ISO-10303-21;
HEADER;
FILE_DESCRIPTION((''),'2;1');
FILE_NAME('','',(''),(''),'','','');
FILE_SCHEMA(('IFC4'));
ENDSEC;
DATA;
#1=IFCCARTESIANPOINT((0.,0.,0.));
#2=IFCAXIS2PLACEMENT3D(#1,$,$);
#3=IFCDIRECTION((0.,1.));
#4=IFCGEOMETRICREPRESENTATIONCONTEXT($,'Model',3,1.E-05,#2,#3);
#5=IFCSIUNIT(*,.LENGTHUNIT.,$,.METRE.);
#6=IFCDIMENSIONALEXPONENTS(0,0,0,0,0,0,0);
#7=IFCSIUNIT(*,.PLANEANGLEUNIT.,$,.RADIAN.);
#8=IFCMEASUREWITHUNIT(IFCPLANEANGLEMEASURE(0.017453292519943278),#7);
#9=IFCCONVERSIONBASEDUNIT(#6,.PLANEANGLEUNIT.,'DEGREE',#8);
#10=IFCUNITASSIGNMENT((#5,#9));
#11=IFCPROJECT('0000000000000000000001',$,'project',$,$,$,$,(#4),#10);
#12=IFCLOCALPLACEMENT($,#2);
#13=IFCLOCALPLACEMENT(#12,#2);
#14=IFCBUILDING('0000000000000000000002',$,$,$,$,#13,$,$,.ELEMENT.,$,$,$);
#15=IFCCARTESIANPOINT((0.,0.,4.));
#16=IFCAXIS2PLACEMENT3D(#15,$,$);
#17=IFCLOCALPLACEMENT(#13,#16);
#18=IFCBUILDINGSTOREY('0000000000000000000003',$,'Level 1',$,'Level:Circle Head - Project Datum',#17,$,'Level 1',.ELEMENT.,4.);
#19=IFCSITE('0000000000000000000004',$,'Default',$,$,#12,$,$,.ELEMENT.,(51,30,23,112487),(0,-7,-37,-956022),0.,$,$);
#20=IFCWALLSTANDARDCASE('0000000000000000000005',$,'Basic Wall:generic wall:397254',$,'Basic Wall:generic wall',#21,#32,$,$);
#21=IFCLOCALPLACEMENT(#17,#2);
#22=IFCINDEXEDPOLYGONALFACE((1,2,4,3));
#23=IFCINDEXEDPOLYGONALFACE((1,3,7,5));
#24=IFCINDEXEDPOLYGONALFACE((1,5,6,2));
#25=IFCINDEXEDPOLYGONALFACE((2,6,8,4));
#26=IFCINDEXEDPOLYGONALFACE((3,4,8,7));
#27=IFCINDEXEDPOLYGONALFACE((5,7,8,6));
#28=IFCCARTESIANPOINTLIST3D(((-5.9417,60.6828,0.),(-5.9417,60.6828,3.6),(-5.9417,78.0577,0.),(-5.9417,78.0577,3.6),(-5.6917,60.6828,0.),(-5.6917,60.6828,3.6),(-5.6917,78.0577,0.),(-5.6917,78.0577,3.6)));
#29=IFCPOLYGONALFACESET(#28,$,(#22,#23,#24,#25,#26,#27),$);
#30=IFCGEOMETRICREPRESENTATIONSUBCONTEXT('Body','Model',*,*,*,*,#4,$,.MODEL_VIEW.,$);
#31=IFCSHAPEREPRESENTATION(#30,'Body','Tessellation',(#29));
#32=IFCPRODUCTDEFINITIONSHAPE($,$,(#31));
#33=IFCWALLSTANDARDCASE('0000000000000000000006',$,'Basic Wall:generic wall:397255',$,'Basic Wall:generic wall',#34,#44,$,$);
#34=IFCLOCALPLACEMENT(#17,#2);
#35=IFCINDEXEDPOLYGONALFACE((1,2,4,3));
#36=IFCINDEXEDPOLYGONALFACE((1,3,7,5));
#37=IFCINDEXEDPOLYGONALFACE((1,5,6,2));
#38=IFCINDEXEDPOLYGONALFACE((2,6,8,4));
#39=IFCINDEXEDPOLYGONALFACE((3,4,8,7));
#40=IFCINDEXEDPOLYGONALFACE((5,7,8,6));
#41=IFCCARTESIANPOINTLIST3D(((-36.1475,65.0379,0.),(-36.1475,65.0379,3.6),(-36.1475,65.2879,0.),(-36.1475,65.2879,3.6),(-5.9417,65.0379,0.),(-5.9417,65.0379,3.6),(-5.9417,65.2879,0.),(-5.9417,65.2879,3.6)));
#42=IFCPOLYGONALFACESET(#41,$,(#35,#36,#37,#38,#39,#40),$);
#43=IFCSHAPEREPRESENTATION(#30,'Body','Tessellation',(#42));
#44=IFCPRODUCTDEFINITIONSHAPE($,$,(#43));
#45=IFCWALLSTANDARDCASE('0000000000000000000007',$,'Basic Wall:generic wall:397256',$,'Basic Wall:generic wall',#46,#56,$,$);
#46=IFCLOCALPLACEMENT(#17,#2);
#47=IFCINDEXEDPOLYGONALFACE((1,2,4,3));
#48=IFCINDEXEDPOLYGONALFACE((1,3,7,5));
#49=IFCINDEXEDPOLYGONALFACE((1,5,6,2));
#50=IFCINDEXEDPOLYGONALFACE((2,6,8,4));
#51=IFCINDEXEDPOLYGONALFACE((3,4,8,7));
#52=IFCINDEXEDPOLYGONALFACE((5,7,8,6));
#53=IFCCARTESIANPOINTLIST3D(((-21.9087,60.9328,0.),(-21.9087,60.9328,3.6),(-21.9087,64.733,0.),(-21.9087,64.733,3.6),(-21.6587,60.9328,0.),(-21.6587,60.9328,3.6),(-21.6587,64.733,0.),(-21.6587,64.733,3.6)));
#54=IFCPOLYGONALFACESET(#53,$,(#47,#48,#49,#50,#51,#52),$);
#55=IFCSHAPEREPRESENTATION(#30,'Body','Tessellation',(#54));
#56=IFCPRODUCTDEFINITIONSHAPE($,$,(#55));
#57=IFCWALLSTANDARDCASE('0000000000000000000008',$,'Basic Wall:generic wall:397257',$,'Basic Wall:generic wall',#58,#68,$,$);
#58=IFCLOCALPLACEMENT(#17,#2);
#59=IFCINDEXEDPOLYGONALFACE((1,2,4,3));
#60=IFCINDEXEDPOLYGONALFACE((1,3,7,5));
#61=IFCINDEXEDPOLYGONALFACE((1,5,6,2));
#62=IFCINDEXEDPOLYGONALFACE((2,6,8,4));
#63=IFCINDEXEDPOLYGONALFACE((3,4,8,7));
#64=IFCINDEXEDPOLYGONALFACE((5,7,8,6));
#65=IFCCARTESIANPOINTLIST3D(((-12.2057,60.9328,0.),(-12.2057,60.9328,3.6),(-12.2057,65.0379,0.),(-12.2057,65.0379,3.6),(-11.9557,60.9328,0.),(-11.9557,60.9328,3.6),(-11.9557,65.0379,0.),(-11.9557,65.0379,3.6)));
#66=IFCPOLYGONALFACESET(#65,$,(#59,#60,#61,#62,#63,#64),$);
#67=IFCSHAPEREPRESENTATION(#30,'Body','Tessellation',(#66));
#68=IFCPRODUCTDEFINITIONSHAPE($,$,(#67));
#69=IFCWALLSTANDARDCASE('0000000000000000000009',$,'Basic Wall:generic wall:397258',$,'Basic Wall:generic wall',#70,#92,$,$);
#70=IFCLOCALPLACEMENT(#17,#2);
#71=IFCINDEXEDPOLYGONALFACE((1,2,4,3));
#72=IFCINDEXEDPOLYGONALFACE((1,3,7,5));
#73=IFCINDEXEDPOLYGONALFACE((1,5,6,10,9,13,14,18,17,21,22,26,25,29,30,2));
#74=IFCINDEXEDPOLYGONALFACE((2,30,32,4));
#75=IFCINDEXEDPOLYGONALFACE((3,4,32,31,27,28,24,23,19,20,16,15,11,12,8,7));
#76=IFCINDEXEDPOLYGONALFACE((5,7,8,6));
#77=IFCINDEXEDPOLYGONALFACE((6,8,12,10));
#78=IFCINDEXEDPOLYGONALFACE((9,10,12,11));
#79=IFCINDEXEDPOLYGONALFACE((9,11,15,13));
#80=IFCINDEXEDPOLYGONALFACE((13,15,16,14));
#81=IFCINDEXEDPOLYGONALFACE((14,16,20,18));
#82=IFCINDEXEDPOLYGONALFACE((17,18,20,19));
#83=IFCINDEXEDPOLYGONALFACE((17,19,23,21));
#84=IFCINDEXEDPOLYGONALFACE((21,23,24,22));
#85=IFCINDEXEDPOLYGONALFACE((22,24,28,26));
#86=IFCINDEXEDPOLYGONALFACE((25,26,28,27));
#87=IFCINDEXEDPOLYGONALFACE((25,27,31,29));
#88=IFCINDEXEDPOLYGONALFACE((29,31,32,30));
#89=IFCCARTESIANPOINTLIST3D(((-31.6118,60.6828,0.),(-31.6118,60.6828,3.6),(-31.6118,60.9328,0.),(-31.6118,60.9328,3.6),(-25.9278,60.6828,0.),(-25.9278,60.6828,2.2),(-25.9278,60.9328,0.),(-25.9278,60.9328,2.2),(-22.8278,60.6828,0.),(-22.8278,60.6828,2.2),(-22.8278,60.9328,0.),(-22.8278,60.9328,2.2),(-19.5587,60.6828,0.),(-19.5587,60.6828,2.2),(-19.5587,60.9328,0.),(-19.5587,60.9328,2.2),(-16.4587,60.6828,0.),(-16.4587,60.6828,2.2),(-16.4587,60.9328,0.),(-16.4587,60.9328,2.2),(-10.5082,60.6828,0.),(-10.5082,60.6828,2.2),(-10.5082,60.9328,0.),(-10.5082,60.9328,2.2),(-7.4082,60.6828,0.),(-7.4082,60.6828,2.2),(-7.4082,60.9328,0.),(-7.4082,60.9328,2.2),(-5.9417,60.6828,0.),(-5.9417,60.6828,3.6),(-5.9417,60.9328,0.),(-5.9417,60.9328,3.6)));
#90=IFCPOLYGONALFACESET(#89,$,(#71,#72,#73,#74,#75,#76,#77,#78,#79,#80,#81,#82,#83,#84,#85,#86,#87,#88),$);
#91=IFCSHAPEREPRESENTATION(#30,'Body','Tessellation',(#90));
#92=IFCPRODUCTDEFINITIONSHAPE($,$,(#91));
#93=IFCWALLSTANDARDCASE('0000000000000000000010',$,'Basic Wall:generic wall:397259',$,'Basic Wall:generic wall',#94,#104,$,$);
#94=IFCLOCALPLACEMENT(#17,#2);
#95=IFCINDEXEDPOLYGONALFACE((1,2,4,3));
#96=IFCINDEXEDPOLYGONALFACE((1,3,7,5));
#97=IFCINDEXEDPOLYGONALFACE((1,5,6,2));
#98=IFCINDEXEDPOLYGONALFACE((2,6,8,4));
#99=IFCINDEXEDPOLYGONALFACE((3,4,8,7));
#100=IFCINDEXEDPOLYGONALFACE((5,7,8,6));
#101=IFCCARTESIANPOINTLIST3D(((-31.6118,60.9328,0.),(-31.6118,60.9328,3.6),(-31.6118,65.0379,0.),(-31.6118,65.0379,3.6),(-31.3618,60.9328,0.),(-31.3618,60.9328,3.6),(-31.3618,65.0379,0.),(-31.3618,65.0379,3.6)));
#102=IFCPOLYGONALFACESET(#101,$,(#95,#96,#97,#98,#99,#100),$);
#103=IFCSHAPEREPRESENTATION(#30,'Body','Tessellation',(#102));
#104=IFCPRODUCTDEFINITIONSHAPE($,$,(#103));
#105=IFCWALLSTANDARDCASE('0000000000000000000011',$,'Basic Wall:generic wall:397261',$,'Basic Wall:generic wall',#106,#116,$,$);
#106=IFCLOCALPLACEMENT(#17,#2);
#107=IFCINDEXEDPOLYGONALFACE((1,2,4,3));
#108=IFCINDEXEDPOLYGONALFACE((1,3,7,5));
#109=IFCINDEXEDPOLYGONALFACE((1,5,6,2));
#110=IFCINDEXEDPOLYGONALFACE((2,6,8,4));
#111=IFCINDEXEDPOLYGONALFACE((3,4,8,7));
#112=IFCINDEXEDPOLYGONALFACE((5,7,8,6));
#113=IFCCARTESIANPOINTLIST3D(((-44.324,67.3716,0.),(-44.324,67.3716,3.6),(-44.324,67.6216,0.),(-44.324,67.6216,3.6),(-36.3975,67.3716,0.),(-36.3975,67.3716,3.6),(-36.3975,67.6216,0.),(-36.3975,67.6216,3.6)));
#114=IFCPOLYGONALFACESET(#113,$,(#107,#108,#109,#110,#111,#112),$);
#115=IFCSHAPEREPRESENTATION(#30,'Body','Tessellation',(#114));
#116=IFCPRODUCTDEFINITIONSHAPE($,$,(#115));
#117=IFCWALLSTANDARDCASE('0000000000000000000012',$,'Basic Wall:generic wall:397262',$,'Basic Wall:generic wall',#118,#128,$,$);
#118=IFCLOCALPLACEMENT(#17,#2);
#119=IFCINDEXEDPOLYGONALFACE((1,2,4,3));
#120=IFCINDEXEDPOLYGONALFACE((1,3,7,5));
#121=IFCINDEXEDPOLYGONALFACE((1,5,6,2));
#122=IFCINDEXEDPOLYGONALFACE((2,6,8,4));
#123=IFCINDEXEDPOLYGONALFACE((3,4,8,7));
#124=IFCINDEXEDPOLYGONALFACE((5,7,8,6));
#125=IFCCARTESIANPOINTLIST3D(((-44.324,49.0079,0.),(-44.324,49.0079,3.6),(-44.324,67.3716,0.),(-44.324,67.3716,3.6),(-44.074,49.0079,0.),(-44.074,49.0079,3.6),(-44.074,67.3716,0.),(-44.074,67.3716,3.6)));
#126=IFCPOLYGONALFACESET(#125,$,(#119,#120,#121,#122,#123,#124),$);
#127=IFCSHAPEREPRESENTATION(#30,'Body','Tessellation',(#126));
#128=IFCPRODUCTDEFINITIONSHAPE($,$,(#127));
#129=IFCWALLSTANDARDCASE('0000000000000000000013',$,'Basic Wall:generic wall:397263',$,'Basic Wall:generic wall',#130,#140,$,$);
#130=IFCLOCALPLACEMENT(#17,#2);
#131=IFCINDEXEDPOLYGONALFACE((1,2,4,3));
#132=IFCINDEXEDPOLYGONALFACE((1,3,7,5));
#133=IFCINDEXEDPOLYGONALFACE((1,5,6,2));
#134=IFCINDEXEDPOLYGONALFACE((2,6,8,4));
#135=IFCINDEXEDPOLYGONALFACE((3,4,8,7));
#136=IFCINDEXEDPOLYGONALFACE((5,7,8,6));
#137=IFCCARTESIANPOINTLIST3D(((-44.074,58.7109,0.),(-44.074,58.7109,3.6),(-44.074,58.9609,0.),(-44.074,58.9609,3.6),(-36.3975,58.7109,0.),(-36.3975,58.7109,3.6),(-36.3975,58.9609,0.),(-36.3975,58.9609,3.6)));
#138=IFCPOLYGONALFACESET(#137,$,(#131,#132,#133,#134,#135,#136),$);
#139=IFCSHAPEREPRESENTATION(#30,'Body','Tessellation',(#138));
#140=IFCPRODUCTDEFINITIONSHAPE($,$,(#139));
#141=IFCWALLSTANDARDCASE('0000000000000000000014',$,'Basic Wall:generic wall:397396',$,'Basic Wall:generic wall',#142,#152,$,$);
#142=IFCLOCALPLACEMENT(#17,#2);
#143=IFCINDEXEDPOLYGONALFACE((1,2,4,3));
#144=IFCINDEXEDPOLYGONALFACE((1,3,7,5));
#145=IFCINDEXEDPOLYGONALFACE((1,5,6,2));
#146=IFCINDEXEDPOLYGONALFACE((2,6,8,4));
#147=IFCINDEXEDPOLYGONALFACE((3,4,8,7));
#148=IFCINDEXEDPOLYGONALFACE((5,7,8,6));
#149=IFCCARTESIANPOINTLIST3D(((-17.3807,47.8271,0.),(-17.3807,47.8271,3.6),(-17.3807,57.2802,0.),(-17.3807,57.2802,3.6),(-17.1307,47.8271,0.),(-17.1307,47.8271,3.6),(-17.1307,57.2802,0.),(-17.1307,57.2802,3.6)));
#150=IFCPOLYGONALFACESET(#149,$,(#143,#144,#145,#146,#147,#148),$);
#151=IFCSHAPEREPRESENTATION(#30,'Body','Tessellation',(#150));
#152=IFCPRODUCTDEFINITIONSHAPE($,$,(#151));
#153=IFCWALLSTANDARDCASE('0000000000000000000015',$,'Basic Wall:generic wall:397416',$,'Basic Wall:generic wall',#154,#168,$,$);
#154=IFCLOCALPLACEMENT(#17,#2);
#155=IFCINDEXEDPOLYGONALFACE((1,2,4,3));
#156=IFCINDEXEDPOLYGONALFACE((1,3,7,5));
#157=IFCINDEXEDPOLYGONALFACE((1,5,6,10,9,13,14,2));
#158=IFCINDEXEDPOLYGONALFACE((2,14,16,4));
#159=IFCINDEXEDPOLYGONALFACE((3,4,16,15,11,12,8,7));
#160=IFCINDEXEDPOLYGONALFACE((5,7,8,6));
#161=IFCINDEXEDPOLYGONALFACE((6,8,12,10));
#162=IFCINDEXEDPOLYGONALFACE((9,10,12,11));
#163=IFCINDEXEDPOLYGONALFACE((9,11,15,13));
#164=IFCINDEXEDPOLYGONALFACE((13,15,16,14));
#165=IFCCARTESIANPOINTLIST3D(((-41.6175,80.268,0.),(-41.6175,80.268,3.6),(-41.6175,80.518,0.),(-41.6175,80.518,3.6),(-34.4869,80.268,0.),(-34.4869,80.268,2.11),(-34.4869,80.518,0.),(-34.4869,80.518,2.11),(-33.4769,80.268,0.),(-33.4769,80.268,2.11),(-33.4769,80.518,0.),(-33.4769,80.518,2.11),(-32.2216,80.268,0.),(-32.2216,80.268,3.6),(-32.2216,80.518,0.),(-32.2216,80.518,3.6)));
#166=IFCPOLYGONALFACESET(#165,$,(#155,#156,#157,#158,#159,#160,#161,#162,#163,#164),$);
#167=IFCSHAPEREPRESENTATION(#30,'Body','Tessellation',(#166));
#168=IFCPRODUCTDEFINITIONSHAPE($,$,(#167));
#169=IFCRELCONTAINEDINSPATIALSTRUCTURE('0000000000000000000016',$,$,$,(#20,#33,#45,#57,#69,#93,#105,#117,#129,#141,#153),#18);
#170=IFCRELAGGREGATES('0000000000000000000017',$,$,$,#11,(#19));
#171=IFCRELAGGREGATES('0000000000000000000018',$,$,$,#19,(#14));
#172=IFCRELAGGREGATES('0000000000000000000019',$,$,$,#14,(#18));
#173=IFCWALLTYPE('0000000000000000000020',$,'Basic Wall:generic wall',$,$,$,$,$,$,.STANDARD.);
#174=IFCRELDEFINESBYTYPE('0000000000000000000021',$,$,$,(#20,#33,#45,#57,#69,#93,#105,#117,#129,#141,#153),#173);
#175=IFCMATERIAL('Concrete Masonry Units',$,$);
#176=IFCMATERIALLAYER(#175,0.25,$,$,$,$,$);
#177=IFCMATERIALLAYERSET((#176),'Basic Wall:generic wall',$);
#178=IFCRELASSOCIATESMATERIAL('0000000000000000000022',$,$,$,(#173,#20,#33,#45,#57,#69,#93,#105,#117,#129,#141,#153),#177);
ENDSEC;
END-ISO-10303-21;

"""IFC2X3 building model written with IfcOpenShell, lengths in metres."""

from ifc_helpers import new_model, entity, si_unit, converted_unit, direction, frame, frame_2d, origin, place, context, subcontext, project, spatial, rectangle, extrude, material, layer, layer_set, layer_usage, type_object, element, save


model = new_model("IFC2X3")

# Units and contexts
model_context = context("Model", 3, precision=1e-05, world=origin(), true_north=direction((0.0, 1.0)))
body_context = subcontext(model_context, "Body", "Model", "MODEL_VIEW")
ifc_project = project(units=[si_unit("LENGTHUNIT", "METRE"), converted_unit("PLANEANGLEUNIT", "DEGREE", entity("IfcPlaneAngleMeasure", 0.017453292519943278), si_unit("PLANEANGLEUNIT", "RADIAN"), dimensions=[0, 0, 0, 0, 0, 0, 0])], contexts=[model_context])

# Site, building, storey
site_placement = place(None, origin())
site = spatial("IfcSite", under=ifc_project, at=site_placement, Name="Default", CompositionType="ELEMENT", RefLatitude=(51, 30, 23, 112487), RefLongitude=(0, -7, -37, -956022), RefElevation=0.0)
building_placement = place(site_placement, origin())
building = spatial("IfcBuilding", under=site, at=building_placement, CompositionType="ELEMENT")
storey_placement = place(building_placement, frame((0.0, 0.0, 4.0)))
storey = spatial("IfcBuildingStorey", under=building, at=storey_placement, Name="Level 1", ObjectType="Level:Circle Head - Project Datum", LongName="Level 1", CompositionType="ELEMENT", Elevation=4.0)

# Shared definitions
ifc_material = material(Name="Concrete Masonry Units")
ifc_layer = layer(ifc_material, 0.25)
ifc_layer_set = layer_set([ifc_layer], Name="Basic Wall:generic wall")
wall_type = type_object("IfcWallType", Name="Basic Wall:generic wall", PredefinedType="STANDARD", material=ifc_layer_set)

# Walls
ifc_layer_usage_1 = layer_usage(ifc_layer_set, "AXIS2", "NEGATIVE", 0.125)
wall_1_placement = place(storey_placement, frame((-5.8167, 78.0577, 0.0), z_axis=(0.0, 0.0, 1.0), x_axis=(0.0, -1.0, 0.0)))
element("IfcWallStandardCase", 1, at=wall_1_placement, inside=storey, type_object=wall_type, material=ifc_layer_usage_1, Name="Basic Wall:generic wall:397254", ObjectType="Basic Wall:generic wall", context=body_context, shape_type="SweptSolid", body=[
    extrude(rectangle(XDim=17.3749, YDim=0.25, at=frame_2d((8.6874, 0.0), x_axis=(-1.0, 0.0))), origin(), (0.0, 0.0, 1.0), 3.6),
])
ifc_layer_usage_2 = layer_usage(ifc_layer_set, "AXIS2", "NEGATIVE", 0.125)
wall_2_placement = place(storey_placement, frame((-5.9417, 65.1629, 0.0), z_axis=(0.0, 0.0, 1.0), x_axis=(-1.0, 0.0, 0.0)))
element("IfcWallStandardCase", 2, at=wall_2_placement, inside=storey, type_object=wall_type, material=ifc_layer_usage_2, Name="Basic Wall:generic wall:397255", ObjectType="Basic Wall:generic wall", context=body_context, shape_type="SweptSolid", body=[
    extrude(rectangle(XDim=30.2059, YDim=0.25, at=frame_2d((15.1029, 0.0), x_axis=(-1.0, 0.0))), origin(), (0.0, 0.0, 1.0), 3.6),
])
ifc_layer_usage_3 = layer_usage(ifc_layer_set, "AXIS2", "NEGATIVE", 0.125)
wall_3_placement = place(storey_placement, frame((-21.7837, 64.733, 0.0), z_axis=(0.0, 0.0, 1.0), x_axis=(0.0, -1.0, 0.0)))
element("IfcWallStandardCase", 3, at=wall_3_placement, inside=storey, type_object=wall_type, material=ifc_layer_usage_3, Name="Basic Wall:generic wall:397256", ObjectType="Basic Wall:generic wall", context=body_context, shape_type="SweptSolid", body=[
    extrude(rectangle(XDim=3.8003, YDim=0.25, at=frame_2d((1.9001, 0.0), x_axis=(-1.0, 0.0))), origin(), (0.0, 0.0, 1.0), 3.6),
])
ifc_layer_usage_4 = layer_usage(ifc_layer_set, "AXIS2", "NEGATIVE", 0.125)
wall_4_placement = place(storey_placement, frame((-12.0807, 65.0379, 0.0), z_axis=(0.0, 0.0, 1.0), x_axis=(0.0, -1.0, 0.0)))
element("IfcWallStandardCase", 4, at=wall_4_placement, inside=storey, type_object=wall_type, material=ifc_layer_usage_4, Name="Basic Wall:generic wall:397257", ObjectType="Basic Wall:generic wall", context=body_context, shape_type="SweptSolid", body=[
    extrude(rectangle(XDim=4.1051, YDim=0.25, at=frame_2d((2.0526, 0.0), x_axis=(-1.0, 0.0))), origin(), (0.0, 0.0, 1.0), 3.6),
])

# Wall, openings
ifc_layer_usage_5 = layer_usage(ifc_layer_set, "AXIS2", "NEGATIVE", 0.125)
wall_5_placement = place(storey_placement, frame((-5.9417, 60.8078, 0.0), z_axis=(0.0, 0.0, 1.0), x_axis=(-1.0, 0.0, 0.0)))
wall_5 = element("IfcWallStandardCase", 5, at=wall_5_placement, inside=storey, type_object=wall_type, material=ifc_layer_usage_5, Name="Basic Wall:generic wall:397258", ObjectType="Basic Wall:generic wall", context=body_context, shape_type="SweptSolid", body=[
    extrude(rectangle(XDim=25.6701, YDim=0.25, at=frame_2d((12.8351, 0.0), x_axis=(1.0, 0.0))), origin(), (0.0, 0.0, 1.0), 3.6),
])
opening_1_placement = place(wall_5_placement, frame((19.9861, 0.125, 0.0)))
element("IfcOpeningElement", 6, at=opening_1_placement, cuts=wall_5, ObjectType="Opening", context=body_context, shape_type="SweptSolid", body=[
    extrude(rectangle(XDim=2.2, YDim=3.1, at=frame_2d((1.1, 1.55), x_axis=(1.0, 0.0))), frame((0.0, 0.0, 0.0), z_axis=(0.0, -1.0, 0.0), x_axis=(0.0, 0.0, 1.0)), (0.0, 0.0, 1.0), 0.25),
])
opening_2_placement = place(wall_5_placement, frame((13.6171, 0.125, 0.0)))
element("IfcOpeningElement", 7, at=opening_2_placement, cuts=wall_5, ObjectType="Opening", context=body_context, shape_type="SweptSolid", body=[
    extrude(rectangle(XDim=2.2, YDim=3.1, at=frame_2d((1.1, 1.55), x_axis=(1.0, 0.0))), frame((0.0, 0.0, 0.0), z_axis=(0.0, -1.0, 0.0), x_axis=(0.0, 0.0, 1.0)), (0.0, 0.0, 1.0), 0.25),
])
opening_3_placement = place(wall_5_placement, frame((4.5665, 0.125, 0.0)))
element("IfcOpeningElement", 8, at=opening_3_placement, cuts=wall_5, ObjectType="Opening", context=body_context, shape_type="SweptSolid", body=[
    extrude(rectangle(XDim=2.2, YDim=3.1, at=frame_2d((1.1, 1.55), x_axis=(1.0, 0.0))), frame((0.0, 0.0, 0.0), z_axis=(0.0, -1.0, 0.0), x_axis=(0.0, 0.0, 1.0)), (0.0, 0.0, 1.0), 0.25),
])

# Walls
ifc_layer_usage_6 = layer_usage(ifc_layer_set, "AXIS2", "NEGATIVE", 0.125)
wall_6_placement = place(storey_placement, frame((-31.4868, 65.0379, 0.0), z_axis=(0.0, 0.0, 1.0), x_axis=(0.0, -1.0, 0.0)))
element("IfcWallStandardCase", 9, at=wall_6_placement, inside=storey, type_object=wall_type, material=ifc_layer_usage_6, Name="Basic Wall:generic wall:397259", ObjectType="Basic Wall:generic wall", context=body_context, shape_type="SweptSolid", body=[
    extrude(rectangle(XDim=4.1051, YDim=0.25, at=frame_2d((2.0526, 0.0), x_axis=(-1.0, 0.0))), origin(), (0.0, 0.0, 1.0), 3.6),
])
ifc_layer_usage_7 = layer_usage(ifc_layer_set, "AXIS2", "NEGATIVE", 0.125)
wall_7_placement = place(storey_placement, frame((-36.3975, 67.4966, 0.0), z_axis=(0.0, 0.0, 1.0), x_axis=(-1.0, 0.0, 0.0)))
element("IfcWallStandardCase", 10, at=wall_7_placement, inside=storey, type_object=wall_type, material=ifc_layer_usage_7, Name="Basic Wall:generic wall:397261", ObjectType="Basic Wall:generic wall", context=body_context, shape_type="SweptSolid", body=[
    extrude(rectangle(XDim=7.9265, YDim=0.25, at=frame_2d((3.9632, 0.0), x_axis=(-1.0, 0.0))), origin(), (0.0, 0.0, 1.0), 3.6),
])
ifc_layer_usage_8 = layer_usage(ifc_layer_set, "AXIS2", "NEGATIVE", 0.125)
wall_8_placement = place(storey_placement, frame((-44.199, 67.3716, 0.0), z_axis=(0.0, 0.0, 1.0), x_axis=(0.0, -1.0, 0.0)))
element("IfcWallStandardCase", 11, at=wall_8_placement, inside=storey, type_object=wall_type, material=ifc_layer_usage_8, Name="Basic Wall:generic wall:397262", ObjectType="Basic Wall:generic wall", context=body_context, shape_type="SweptSolid", body=[
    extrude(rectangle(XDim=18.3637, YDim=0.25, at=frame_2d((9.1819, 0.0), x_axis=(-1.0, 0.0))), origin(), (0.0, 0.0, 1.0), 3.6),
])
ifc_layer_usage_9 = layer_usage(ifc_layer_set, "AXIS2", "NEGATIVE", 0.125)
wall_9_placement = place(storey_placement, frame((-44.074, 58.8359, 0.0)))
element("IfcWallStandardCase", 12, at=wall_9_placement, inside=storey, type_object=wall_type, material=ifc_layer_usage_9, Name="Basic Wall:generic wall:397263", ObjectType="Basic Wall:generic wall", context=body_context, shape_type="SweptSolid", body=[
    extrude(rectangle(XDim=7.6765, YDim=0.25, at=frame_2d((3.8382, 0.0), x_axis=(-1.0, 0.0))), origin(), (0.0, 0.0, 1.0), 3.6),
])
ifc_layer_usage_10 = layer_usage(ifc_layer_set, "AXIS2", "NEGATIVE", 0.125)
wall_10_placement = place(storey_placement, frame((-17.2557, 57.2802, 0.0), z_axis=(0.0, 0.0, 1.0), x_axis=(0.0, -1.0, 0.0)))
element("IfcWallStandardCase", 13, at=wall_10_placement, inside=storey, type_object=wall_type, material=ifc_layer_usage_10, Name="Basic Wall:generic wall:397396", ObjectType="Basic Wall:generic wall", context=body_context, shape_type="SweptSolid", body=[
    extrude(rectangle(XDim=9.4531, YDim=0.25, at=frame_2d((4.7265, 0.0), x_axis=(-1.0, 0.0))), origin(), (0.0, 0.0, 1.0), 3.6),
])

# Wall, opening
ifc_layer_usage_11 = layer_usage(ifc_layer_set, "AXIS2", "POSITIVE", -0.125)
wall_11_placement = place(storey_placement, frame((-41.6175, 80.393, 0.0)))
wall_11 = element("IfcWallStandardCase", 14, at=wall_11_placement, inside=storey, type_object=wall_type, material=ifc_layer_usage_11, Name="Basic Wall:generic wall:397416", ObjectType="Basic Wall:generic wall", context=body_context, shape_type="SweptSolid", body=[
    extrude(rectangle(XDim=9.396, YDim=0.25, at=frame_2d((4.698, 0.0), x_axis=(-1.0, 0.0))), origin(), (0.0, 0.0, 1.0), 3.6),
])
opening_4_placement = place(wall_11_placement, frame((7.1307, -0.125, 0.0)))
element("IfcOpeningElement", 15, at=opening_4_placement, cuts=wall_11, ObjectType="Opening", context=body_context, shape_type="SweptSolid", body=[
    extrude(rectangle(XDim=2.11, YDim=1.01, at=frame_2d((1.055, 0.505), x_axis=(1.0, 0.0))), frame((0.0, 0.0, 0.0), z_axis=(0.0, 1.0, 0.0), x_axis=(0.0, 0.0, 1.0)), (0.0, 0.0, 1.0), 0.25),
])

save(model, "model.ifc")
